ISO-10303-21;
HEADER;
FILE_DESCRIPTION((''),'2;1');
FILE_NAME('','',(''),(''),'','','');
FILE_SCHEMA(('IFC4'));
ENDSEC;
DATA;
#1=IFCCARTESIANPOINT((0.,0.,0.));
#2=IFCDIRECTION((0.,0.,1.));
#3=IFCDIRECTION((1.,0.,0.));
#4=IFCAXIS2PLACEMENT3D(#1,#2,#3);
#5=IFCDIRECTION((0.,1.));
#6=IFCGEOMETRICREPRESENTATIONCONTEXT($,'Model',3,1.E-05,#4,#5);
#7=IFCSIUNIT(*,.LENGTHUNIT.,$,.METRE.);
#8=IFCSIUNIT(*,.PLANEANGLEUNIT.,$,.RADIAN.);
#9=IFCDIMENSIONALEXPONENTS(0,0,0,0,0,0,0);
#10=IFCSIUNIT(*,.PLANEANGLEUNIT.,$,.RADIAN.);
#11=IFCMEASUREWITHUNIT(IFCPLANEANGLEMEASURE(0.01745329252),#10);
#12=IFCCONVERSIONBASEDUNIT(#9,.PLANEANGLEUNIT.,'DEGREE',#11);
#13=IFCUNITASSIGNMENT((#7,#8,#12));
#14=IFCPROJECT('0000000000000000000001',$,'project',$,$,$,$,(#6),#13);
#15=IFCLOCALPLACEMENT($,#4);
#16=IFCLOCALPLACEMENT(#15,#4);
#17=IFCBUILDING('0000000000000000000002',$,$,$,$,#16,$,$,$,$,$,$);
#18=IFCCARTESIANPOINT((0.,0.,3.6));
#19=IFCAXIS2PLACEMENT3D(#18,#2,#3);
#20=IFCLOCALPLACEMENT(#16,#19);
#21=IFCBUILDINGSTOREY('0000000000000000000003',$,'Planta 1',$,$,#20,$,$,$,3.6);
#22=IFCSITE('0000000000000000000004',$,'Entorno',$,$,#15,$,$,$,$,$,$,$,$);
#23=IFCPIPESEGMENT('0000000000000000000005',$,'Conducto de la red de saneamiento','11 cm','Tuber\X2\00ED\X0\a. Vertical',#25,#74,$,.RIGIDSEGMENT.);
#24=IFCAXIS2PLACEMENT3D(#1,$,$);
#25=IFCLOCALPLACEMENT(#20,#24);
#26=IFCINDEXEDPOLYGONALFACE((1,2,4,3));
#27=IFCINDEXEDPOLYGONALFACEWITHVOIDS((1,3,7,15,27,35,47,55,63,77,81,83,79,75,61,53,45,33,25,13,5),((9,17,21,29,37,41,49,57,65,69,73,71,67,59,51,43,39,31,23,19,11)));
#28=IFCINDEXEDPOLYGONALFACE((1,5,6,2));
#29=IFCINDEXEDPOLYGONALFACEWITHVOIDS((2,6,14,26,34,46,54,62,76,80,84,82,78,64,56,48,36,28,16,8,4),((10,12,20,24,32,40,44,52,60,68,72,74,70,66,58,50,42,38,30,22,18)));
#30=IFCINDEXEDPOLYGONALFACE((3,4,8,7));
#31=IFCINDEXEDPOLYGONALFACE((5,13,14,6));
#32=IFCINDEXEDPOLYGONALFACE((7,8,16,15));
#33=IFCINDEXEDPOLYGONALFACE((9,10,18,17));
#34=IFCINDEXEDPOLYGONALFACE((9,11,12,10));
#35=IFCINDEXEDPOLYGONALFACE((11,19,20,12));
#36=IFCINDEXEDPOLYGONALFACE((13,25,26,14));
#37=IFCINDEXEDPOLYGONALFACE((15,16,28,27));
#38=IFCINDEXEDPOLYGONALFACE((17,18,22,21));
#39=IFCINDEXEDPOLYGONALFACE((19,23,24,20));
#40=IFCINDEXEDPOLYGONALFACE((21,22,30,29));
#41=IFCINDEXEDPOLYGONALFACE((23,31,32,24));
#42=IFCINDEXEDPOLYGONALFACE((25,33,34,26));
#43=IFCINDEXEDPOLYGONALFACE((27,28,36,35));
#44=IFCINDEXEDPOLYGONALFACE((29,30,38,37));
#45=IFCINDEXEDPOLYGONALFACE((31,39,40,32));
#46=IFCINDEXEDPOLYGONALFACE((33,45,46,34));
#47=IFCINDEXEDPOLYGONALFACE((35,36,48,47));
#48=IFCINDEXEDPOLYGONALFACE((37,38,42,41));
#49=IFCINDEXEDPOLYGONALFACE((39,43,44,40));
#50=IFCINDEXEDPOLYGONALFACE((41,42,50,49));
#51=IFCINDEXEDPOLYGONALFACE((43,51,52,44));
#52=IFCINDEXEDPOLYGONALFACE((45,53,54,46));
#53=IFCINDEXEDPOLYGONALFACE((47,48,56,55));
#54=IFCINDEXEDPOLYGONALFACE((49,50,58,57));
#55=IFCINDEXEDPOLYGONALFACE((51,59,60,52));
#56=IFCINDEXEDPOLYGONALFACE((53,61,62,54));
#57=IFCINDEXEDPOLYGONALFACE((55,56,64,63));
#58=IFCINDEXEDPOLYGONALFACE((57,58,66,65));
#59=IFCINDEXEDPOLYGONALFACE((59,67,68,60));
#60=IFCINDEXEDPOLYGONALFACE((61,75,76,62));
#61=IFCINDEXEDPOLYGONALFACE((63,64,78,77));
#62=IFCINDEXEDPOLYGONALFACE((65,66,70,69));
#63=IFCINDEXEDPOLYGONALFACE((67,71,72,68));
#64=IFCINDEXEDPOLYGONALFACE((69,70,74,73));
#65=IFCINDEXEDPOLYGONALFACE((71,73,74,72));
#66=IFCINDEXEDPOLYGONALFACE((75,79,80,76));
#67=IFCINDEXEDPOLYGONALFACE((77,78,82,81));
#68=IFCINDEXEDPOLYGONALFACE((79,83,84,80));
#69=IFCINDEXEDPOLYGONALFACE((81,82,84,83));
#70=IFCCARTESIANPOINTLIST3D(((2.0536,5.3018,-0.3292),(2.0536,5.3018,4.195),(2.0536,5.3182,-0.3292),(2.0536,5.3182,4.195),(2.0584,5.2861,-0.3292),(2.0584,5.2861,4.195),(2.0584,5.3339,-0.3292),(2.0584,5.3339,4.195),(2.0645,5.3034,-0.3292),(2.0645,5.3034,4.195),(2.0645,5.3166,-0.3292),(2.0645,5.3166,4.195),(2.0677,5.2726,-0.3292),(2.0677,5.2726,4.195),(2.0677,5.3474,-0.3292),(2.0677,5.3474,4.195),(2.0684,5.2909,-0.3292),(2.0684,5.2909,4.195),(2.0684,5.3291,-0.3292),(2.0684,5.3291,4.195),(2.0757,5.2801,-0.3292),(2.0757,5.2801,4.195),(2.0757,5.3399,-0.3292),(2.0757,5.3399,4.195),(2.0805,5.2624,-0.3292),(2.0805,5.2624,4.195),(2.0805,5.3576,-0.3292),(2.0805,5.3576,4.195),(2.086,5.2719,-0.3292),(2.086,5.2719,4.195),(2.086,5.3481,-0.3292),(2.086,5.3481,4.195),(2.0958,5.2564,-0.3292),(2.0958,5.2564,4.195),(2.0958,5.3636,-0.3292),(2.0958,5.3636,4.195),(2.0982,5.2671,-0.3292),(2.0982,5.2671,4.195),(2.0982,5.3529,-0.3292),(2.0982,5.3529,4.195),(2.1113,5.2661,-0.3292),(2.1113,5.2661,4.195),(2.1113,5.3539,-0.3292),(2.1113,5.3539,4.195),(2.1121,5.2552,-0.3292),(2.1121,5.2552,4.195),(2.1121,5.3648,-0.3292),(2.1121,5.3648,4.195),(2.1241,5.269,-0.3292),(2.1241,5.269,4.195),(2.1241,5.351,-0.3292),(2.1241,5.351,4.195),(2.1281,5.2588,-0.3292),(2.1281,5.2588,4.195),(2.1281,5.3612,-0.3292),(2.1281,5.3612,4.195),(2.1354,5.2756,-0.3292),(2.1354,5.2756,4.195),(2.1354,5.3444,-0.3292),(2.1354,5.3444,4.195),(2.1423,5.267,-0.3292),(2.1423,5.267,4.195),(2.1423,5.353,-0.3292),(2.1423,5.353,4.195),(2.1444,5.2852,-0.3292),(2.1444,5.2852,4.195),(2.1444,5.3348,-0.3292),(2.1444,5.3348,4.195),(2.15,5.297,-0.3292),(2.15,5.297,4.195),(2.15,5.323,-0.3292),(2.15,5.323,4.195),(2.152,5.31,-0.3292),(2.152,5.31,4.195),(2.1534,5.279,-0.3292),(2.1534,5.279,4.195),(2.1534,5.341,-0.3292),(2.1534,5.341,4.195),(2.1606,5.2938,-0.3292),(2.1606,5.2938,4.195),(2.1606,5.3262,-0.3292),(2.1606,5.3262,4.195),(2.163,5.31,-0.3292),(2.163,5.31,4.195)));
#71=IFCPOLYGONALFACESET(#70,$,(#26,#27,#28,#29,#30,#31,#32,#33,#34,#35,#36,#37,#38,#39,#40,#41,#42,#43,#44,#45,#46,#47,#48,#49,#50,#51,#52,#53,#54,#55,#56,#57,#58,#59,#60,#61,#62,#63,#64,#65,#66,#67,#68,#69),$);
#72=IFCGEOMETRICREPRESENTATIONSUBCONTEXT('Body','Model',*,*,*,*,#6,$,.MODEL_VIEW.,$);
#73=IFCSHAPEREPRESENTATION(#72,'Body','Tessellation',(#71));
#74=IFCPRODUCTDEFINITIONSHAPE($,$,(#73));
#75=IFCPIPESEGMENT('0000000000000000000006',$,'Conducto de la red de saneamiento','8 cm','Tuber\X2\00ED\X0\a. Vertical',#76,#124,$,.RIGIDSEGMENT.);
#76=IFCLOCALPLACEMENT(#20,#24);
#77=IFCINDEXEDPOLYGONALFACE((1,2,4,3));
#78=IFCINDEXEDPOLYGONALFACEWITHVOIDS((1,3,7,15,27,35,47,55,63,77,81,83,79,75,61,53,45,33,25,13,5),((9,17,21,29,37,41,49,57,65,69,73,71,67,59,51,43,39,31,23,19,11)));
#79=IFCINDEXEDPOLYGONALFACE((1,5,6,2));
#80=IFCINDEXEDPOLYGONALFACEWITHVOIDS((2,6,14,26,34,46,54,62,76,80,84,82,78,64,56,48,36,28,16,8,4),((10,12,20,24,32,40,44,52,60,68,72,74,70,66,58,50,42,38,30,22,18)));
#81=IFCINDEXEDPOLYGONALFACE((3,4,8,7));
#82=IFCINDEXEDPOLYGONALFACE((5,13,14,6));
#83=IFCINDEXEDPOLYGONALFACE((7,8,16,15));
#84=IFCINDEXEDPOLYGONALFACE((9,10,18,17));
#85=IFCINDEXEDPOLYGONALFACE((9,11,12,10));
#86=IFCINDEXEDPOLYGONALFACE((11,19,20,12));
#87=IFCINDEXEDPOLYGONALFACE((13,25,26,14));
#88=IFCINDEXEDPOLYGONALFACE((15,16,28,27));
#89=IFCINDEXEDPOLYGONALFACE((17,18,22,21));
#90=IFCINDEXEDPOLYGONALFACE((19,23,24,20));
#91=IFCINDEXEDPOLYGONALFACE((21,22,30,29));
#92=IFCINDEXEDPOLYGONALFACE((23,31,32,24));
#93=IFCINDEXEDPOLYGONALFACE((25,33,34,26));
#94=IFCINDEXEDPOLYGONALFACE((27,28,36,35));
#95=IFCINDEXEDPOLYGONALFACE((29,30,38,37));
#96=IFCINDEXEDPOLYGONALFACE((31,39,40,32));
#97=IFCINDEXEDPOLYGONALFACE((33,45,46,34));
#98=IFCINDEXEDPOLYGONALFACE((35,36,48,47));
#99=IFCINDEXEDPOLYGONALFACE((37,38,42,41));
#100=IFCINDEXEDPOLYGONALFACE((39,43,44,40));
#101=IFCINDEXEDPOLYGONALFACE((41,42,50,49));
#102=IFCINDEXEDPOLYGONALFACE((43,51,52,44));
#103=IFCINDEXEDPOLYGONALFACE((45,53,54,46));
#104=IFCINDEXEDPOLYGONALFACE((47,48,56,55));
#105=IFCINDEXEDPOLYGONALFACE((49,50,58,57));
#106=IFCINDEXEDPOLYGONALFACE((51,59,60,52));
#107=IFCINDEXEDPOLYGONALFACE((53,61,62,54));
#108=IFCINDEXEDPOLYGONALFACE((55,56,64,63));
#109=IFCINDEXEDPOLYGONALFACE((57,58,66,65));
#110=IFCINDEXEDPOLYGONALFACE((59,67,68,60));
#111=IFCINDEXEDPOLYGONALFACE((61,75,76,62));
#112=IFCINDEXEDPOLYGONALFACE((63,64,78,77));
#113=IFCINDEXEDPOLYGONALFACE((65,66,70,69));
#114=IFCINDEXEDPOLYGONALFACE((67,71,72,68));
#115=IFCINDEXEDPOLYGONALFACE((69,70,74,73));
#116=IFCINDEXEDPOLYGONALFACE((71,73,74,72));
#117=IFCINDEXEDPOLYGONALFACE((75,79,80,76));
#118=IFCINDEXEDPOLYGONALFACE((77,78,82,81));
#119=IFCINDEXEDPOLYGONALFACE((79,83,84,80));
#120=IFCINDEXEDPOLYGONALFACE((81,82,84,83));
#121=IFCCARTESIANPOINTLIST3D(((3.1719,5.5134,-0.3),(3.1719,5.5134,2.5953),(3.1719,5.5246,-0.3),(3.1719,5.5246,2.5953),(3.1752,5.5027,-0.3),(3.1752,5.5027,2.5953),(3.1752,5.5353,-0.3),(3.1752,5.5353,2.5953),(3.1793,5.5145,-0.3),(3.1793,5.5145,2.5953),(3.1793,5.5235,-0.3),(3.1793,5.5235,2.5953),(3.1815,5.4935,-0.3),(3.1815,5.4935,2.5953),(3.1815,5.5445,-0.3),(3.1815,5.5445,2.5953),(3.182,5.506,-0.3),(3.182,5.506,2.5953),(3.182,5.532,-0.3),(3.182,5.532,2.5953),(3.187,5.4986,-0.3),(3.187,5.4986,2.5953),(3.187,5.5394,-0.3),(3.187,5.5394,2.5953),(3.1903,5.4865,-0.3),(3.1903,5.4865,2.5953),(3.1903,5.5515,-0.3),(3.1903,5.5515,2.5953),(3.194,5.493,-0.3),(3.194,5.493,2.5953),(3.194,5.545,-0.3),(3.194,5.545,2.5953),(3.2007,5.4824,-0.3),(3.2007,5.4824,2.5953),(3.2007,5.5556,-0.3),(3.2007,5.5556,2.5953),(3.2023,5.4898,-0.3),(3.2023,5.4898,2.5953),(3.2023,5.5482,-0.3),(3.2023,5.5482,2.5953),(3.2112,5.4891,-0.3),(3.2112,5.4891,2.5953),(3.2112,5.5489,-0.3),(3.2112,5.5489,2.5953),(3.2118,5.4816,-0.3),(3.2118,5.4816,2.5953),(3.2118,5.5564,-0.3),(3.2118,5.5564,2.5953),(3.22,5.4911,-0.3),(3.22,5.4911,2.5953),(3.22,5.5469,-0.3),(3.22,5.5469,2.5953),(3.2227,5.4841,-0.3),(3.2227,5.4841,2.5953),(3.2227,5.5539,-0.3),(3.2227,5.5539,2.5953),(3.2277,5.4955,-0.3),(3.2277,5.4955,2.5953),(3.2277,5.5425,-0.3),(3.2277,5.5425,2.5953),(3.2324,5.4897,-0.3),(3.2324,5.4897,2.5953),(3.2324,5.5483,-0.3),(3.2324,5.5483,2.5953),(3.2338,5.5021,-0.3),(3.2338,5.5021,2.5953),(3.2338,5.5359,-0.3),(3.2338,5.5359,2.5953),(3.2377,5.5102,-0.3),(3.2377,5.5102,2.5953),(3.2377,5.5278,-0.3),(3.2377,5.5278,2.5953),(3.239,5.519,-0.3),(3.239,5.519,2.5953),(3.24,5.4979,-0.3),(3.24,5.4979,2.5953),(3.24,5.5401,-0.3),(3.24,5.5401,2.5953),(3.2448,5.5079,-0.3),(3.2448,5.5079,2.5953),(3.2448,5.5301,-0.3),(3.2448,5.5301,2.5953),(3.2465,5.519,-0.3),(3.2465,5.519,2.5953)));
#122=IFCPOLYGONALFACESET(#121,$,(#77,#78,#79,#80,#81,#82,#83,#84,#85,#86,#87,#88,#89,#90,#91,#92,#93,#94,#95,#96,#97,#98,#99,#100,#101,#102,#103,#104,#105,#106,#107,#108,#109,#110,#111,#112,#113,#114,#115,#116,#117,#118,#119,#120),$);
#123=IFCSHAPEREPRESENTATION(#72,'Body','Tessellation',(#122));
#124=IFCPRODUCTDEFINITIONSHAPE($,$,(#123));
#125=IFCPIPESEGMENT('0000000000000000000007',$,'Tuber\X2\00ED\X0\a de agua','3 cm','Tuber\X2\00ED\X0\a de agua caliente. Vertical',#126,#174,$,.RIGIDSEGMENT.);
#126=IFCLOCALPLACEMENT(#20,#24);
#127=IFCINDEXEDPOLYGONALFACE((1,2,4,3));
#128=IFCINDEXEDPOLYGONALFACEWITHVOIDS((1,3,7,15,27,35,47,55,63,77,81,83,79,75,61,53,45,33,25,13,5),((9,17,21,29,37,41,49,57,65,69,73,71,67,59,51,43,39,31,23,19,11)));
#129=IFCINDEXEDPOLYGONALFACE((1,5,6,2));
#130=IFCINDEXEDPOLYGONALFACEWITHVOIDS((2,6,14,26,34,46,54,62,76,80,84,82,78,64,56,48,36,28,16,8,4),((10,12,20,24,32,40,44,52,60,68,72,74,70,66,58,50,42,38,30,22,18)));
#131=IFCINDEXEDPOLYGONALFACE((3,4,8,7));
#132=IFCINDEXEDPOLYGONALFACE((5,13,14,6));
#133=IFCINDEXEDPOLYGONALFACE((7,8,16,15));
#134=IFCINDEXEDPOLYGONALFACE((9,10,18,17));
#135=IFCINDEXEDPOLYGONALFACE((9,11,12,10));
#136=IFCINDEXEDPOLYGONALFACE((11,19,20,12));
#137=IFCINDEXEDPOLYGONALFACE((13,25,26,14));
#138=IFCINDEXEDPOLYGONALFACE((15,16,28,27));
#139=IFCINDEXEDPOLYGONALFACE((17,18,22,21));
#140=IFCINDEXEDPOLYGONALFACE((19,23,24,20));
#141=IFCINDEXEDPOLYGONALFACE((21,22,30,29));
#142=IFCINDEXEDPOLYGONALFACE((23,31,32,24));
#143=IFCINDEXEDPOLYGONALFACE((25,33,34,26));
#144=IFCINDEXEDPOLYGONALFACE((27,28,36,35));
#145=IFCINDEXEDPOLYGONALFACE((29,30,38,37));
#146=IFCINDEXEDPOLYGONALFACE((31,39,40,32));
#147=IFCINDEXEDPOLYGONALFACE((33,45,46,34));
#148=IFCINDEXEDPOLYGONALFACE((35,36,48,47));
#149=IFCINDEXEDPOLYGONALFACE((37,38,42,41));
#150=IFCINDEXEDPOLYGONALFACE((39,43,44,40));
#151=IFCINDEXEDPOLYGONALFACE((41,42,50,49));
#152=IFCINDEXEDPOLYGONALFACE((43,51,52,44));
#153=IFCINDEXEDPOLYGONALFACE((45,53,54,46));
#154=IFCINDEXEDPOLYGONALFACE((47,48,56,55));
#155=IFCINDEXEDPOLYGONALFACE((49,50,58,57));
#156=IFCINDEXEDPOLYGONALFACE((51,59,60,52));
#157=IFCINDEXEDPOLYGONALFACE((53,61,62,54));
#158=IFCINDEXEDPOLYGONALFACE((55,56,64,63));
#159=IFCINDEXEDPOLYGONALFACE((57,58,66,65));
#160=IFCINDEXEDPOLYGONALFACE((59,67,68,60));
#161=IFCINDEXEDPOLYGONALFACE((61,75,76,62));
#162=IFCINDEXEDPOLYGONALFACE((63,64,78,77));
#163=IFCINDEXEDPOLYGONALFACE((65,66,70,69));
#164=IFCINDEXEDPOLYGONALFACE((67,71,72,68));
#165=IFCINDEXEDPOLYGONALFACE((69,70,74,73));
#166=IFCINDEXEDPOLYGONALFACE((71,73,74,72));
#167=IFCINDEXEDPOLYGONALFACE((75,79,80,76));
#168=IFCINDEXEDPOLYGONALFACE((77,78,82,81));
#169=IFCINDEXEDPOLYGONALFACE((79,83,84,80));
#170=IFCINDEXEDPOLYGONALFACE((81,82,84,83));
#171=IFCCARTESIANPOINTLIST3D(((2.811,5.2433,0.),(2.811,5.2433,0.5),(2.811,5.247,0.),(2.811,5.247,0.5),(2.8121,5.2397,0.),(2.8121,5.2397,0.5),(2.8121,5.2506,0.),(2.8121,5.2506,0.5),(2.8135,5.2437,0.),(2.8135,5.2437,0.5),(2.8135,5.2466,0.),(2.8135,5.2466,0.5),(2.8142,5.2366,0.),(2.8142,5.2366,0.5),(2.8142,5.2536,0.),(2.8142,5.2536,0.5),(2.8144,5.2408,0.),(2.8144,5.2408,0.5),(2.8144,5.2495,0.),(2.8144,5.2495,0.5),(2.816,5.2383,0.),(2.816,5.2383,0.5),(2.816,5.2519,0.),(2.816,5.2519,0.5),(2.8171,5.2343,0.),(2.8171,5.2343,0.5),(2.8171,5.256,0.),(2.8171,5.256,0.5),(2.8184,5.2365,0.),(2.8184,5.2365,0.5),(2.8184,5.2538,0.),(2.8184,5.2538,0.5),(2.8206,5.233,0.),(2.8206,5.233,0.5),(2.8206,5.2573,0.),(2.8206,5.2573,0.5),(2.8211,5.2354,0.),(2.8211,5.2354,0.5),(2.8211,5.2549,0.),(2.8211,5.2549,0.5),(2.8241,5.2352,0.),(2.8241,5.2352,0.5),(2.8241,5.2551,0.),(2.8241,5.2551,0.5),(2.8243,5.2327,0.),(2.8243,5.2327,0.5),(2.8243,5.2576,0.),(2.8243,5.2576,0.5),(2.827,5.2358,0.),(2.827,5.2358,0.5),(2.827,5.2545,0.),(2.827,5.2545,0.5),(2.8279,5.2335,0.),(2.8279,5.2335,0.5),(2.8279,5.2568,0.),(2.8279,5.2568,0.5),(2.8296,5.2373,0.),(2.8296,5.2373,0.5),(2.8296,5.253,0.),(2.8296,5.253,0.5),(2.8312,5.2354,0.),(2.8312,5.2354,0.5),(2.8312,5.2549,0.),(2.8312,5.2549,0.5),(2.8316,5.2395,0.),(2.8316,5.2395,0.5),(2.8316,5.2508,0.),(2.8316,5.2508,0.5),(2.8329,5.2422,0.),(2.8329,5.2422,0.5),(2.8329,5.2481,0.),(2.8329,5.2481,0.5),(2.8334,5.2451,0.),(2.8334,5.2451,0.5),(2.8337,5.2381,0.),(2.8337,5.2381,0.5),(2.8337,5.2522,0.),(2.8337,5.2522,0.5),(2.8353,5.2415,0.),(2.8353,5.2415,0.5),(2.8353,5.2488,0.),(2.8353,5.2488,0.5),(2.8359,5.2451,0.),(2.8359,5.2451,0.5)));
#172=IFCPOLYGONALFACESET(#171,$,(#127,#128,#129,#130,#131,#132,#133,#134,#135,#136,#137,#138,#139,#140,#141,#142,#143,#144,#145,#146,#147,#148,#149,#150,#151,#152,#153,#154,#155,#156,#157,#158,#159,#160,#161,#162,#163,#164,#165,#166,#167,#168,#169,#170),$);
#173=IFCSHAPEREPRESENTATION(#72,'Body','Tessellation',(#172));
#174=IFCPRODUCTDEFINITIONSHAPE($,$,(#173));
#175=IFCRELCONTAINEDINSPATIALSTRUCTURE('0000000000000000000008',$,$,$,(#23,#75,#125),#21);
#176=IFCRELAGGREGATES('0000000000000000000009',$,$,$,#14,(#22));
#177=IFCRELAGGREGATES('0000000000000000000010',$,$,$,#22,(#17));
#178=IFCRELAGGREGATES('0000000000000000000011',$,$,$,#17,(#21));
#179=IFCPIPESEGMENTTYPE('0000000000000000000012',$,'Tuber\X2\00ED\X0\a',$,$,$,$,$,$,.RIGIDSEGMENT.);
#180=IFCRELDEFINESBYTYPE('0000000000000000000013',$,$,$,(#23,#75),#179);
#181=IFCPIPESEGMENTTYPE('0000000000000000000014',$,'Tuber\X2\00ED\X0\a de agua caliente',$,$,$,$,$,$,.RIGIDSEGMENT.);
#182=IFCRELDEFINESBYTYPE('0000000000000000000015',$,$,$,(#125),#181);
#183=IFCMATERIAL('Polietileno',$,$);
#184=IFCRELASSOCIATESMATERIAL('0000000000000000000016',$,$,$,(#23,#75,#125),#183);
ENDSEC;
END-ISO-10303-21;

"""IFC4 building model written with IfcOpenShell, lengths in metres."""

from ifc_helpers import new_model, entity, si_unit, converted_unit, direction, frame, origin_with_axes, origin_2d_with_axis, place, context, subcontext, project, spatial, hollow_circle, extrude, material, type_object, element, save


model = new_model("IFC4")

# Units and contexts
model_context = context("Model", 3, precision=1e-05, world=origin_with_axes(), true_north=direction((0.0, 1.0)))
body_context = subcontext(model_context, "Body", "Model", "MODEL_VIEW")
ifc_project = project(units=[si_unit("LENGTHUNIT", "METRE"), si_unit("PLANEANGLEUNIT", "RADIAN"), converted_unit("PLANEANGLEUNIT", "DEGREE", entity("IfcPlaneAngleMeasure", 0.01745329252), si_unit("PLANEANGLEUNIT", "RADIAN"), dimensions=[0, 0, 0, 0, 0, 0, 0])], contexts=[model_context])

# Site, building, storey
site_placement = place(None, origin_with_axes())
site = spatial("IfcSite", under=ifc_project, at=site_placement, Name="Entorno")
building_placement = place(site_placement, origin_with_axes())
building = spatial("IfcBuilding", under=site, at=building_placement)
storey_placement = place(building_placement, frame((0.0, 0.0, 3.6), z_axis=(0.0, 0.0, 1.0), x_axis=(1.0, 0.0, 0.0)))
storey = spatial("IfcBuildingStorey", under=building, at=storey_placement, Name="Planta 1", Elevation=3.6)

# Pipe segments
ifc_material_1 = material(Name="Polietileno")
pipe_segment_type_1 = type_object("IfcPipeSegmentType", Name="Tubería", PredefinedType="RIGIDSEGMENT")
pipe_segment_1_placement = place(storey_placement, frame((2.108, 5.31, -0.3292), z_axis=(0.0, 0.0, 1.0), x_axis=(1.0, 0.0, 0.0)))
element("IfcPipeSegment", 1, at=pipe_segment_1_placement, inside=storey, type_object=pipe_segment_type_1, material=ifc_material_1, Name="Conducto de la red de saneamiento", Description="11 cm", ObjectType="Tubería. Vertical", PredefinedType="RIGIDSEGMENT", context=body_context, shape_type="SweptSolid", body=[
    extrude(hollow_circle(Radius=0.055, WallThickness=0.011, at=origin_2d_with_axis()), origin_with_axes(), (0.0, 0.0, 1.0), 4.5242),
])
pipe_segment_2_placement = place(storey_placement, frame((3.209, 5.519, -0.3), z_axis=(0.0, 0.0, 1.0), x_axis=(1.0, 0.0, 0.0)))
element("IfcPipeSegment", 2, at=pipe_segment_2_placement, inside=storey, type_object=pipe_segment_type_1, material=ifc_material_1, Name="Conducto de la red de saneamiento", Description="8 cm", ObjectType="Tubería. Vertical", PredefinedType="RIGIDSEGMENT", context=body_context, shape_type="SweptSolid", body=[
    extrude(hollow_circle(Radius=0.0375, WallThickness=0.0075, at=origin_2d_with_axis()), origin_with_axes(), (0.0, 0.0, 1.0), 2.8953),
])
pipe_segment_type_2 = type_object("IfcPipeSegmentType", Name="Tubería de agua caliente", PredefinedType="RIGIDSEGMENT")
pipe_segment_3_placement = place(storey_placement, frame((2.8234, 5.2451, 0.0), z_axis=(0.0, 0.0, 1.0), x_axis=(1.0, 0.0, 0.0)))
element("IfcPipeSegment", 3, at=pipe_segment_3_placement, inside=storey, type_object=pipe_segment_type_2, material=ifc_material_1, Name="Tubería de agua", Description="3 cm", ObjectType="Tubería de agua caliente. Vertical", PredefinedType="RIGIDSEGMENT", context=body_context, shape_type="SweptSolid", body=[
    extrude(hollow_circle(Radius=0.0125, WallThickness=0.0025, at=origin_2d_with_axis()), origin_with_axes(), (0.0, 0.0, 1.0), 0.5),
])

save(model, "model.ifc")
